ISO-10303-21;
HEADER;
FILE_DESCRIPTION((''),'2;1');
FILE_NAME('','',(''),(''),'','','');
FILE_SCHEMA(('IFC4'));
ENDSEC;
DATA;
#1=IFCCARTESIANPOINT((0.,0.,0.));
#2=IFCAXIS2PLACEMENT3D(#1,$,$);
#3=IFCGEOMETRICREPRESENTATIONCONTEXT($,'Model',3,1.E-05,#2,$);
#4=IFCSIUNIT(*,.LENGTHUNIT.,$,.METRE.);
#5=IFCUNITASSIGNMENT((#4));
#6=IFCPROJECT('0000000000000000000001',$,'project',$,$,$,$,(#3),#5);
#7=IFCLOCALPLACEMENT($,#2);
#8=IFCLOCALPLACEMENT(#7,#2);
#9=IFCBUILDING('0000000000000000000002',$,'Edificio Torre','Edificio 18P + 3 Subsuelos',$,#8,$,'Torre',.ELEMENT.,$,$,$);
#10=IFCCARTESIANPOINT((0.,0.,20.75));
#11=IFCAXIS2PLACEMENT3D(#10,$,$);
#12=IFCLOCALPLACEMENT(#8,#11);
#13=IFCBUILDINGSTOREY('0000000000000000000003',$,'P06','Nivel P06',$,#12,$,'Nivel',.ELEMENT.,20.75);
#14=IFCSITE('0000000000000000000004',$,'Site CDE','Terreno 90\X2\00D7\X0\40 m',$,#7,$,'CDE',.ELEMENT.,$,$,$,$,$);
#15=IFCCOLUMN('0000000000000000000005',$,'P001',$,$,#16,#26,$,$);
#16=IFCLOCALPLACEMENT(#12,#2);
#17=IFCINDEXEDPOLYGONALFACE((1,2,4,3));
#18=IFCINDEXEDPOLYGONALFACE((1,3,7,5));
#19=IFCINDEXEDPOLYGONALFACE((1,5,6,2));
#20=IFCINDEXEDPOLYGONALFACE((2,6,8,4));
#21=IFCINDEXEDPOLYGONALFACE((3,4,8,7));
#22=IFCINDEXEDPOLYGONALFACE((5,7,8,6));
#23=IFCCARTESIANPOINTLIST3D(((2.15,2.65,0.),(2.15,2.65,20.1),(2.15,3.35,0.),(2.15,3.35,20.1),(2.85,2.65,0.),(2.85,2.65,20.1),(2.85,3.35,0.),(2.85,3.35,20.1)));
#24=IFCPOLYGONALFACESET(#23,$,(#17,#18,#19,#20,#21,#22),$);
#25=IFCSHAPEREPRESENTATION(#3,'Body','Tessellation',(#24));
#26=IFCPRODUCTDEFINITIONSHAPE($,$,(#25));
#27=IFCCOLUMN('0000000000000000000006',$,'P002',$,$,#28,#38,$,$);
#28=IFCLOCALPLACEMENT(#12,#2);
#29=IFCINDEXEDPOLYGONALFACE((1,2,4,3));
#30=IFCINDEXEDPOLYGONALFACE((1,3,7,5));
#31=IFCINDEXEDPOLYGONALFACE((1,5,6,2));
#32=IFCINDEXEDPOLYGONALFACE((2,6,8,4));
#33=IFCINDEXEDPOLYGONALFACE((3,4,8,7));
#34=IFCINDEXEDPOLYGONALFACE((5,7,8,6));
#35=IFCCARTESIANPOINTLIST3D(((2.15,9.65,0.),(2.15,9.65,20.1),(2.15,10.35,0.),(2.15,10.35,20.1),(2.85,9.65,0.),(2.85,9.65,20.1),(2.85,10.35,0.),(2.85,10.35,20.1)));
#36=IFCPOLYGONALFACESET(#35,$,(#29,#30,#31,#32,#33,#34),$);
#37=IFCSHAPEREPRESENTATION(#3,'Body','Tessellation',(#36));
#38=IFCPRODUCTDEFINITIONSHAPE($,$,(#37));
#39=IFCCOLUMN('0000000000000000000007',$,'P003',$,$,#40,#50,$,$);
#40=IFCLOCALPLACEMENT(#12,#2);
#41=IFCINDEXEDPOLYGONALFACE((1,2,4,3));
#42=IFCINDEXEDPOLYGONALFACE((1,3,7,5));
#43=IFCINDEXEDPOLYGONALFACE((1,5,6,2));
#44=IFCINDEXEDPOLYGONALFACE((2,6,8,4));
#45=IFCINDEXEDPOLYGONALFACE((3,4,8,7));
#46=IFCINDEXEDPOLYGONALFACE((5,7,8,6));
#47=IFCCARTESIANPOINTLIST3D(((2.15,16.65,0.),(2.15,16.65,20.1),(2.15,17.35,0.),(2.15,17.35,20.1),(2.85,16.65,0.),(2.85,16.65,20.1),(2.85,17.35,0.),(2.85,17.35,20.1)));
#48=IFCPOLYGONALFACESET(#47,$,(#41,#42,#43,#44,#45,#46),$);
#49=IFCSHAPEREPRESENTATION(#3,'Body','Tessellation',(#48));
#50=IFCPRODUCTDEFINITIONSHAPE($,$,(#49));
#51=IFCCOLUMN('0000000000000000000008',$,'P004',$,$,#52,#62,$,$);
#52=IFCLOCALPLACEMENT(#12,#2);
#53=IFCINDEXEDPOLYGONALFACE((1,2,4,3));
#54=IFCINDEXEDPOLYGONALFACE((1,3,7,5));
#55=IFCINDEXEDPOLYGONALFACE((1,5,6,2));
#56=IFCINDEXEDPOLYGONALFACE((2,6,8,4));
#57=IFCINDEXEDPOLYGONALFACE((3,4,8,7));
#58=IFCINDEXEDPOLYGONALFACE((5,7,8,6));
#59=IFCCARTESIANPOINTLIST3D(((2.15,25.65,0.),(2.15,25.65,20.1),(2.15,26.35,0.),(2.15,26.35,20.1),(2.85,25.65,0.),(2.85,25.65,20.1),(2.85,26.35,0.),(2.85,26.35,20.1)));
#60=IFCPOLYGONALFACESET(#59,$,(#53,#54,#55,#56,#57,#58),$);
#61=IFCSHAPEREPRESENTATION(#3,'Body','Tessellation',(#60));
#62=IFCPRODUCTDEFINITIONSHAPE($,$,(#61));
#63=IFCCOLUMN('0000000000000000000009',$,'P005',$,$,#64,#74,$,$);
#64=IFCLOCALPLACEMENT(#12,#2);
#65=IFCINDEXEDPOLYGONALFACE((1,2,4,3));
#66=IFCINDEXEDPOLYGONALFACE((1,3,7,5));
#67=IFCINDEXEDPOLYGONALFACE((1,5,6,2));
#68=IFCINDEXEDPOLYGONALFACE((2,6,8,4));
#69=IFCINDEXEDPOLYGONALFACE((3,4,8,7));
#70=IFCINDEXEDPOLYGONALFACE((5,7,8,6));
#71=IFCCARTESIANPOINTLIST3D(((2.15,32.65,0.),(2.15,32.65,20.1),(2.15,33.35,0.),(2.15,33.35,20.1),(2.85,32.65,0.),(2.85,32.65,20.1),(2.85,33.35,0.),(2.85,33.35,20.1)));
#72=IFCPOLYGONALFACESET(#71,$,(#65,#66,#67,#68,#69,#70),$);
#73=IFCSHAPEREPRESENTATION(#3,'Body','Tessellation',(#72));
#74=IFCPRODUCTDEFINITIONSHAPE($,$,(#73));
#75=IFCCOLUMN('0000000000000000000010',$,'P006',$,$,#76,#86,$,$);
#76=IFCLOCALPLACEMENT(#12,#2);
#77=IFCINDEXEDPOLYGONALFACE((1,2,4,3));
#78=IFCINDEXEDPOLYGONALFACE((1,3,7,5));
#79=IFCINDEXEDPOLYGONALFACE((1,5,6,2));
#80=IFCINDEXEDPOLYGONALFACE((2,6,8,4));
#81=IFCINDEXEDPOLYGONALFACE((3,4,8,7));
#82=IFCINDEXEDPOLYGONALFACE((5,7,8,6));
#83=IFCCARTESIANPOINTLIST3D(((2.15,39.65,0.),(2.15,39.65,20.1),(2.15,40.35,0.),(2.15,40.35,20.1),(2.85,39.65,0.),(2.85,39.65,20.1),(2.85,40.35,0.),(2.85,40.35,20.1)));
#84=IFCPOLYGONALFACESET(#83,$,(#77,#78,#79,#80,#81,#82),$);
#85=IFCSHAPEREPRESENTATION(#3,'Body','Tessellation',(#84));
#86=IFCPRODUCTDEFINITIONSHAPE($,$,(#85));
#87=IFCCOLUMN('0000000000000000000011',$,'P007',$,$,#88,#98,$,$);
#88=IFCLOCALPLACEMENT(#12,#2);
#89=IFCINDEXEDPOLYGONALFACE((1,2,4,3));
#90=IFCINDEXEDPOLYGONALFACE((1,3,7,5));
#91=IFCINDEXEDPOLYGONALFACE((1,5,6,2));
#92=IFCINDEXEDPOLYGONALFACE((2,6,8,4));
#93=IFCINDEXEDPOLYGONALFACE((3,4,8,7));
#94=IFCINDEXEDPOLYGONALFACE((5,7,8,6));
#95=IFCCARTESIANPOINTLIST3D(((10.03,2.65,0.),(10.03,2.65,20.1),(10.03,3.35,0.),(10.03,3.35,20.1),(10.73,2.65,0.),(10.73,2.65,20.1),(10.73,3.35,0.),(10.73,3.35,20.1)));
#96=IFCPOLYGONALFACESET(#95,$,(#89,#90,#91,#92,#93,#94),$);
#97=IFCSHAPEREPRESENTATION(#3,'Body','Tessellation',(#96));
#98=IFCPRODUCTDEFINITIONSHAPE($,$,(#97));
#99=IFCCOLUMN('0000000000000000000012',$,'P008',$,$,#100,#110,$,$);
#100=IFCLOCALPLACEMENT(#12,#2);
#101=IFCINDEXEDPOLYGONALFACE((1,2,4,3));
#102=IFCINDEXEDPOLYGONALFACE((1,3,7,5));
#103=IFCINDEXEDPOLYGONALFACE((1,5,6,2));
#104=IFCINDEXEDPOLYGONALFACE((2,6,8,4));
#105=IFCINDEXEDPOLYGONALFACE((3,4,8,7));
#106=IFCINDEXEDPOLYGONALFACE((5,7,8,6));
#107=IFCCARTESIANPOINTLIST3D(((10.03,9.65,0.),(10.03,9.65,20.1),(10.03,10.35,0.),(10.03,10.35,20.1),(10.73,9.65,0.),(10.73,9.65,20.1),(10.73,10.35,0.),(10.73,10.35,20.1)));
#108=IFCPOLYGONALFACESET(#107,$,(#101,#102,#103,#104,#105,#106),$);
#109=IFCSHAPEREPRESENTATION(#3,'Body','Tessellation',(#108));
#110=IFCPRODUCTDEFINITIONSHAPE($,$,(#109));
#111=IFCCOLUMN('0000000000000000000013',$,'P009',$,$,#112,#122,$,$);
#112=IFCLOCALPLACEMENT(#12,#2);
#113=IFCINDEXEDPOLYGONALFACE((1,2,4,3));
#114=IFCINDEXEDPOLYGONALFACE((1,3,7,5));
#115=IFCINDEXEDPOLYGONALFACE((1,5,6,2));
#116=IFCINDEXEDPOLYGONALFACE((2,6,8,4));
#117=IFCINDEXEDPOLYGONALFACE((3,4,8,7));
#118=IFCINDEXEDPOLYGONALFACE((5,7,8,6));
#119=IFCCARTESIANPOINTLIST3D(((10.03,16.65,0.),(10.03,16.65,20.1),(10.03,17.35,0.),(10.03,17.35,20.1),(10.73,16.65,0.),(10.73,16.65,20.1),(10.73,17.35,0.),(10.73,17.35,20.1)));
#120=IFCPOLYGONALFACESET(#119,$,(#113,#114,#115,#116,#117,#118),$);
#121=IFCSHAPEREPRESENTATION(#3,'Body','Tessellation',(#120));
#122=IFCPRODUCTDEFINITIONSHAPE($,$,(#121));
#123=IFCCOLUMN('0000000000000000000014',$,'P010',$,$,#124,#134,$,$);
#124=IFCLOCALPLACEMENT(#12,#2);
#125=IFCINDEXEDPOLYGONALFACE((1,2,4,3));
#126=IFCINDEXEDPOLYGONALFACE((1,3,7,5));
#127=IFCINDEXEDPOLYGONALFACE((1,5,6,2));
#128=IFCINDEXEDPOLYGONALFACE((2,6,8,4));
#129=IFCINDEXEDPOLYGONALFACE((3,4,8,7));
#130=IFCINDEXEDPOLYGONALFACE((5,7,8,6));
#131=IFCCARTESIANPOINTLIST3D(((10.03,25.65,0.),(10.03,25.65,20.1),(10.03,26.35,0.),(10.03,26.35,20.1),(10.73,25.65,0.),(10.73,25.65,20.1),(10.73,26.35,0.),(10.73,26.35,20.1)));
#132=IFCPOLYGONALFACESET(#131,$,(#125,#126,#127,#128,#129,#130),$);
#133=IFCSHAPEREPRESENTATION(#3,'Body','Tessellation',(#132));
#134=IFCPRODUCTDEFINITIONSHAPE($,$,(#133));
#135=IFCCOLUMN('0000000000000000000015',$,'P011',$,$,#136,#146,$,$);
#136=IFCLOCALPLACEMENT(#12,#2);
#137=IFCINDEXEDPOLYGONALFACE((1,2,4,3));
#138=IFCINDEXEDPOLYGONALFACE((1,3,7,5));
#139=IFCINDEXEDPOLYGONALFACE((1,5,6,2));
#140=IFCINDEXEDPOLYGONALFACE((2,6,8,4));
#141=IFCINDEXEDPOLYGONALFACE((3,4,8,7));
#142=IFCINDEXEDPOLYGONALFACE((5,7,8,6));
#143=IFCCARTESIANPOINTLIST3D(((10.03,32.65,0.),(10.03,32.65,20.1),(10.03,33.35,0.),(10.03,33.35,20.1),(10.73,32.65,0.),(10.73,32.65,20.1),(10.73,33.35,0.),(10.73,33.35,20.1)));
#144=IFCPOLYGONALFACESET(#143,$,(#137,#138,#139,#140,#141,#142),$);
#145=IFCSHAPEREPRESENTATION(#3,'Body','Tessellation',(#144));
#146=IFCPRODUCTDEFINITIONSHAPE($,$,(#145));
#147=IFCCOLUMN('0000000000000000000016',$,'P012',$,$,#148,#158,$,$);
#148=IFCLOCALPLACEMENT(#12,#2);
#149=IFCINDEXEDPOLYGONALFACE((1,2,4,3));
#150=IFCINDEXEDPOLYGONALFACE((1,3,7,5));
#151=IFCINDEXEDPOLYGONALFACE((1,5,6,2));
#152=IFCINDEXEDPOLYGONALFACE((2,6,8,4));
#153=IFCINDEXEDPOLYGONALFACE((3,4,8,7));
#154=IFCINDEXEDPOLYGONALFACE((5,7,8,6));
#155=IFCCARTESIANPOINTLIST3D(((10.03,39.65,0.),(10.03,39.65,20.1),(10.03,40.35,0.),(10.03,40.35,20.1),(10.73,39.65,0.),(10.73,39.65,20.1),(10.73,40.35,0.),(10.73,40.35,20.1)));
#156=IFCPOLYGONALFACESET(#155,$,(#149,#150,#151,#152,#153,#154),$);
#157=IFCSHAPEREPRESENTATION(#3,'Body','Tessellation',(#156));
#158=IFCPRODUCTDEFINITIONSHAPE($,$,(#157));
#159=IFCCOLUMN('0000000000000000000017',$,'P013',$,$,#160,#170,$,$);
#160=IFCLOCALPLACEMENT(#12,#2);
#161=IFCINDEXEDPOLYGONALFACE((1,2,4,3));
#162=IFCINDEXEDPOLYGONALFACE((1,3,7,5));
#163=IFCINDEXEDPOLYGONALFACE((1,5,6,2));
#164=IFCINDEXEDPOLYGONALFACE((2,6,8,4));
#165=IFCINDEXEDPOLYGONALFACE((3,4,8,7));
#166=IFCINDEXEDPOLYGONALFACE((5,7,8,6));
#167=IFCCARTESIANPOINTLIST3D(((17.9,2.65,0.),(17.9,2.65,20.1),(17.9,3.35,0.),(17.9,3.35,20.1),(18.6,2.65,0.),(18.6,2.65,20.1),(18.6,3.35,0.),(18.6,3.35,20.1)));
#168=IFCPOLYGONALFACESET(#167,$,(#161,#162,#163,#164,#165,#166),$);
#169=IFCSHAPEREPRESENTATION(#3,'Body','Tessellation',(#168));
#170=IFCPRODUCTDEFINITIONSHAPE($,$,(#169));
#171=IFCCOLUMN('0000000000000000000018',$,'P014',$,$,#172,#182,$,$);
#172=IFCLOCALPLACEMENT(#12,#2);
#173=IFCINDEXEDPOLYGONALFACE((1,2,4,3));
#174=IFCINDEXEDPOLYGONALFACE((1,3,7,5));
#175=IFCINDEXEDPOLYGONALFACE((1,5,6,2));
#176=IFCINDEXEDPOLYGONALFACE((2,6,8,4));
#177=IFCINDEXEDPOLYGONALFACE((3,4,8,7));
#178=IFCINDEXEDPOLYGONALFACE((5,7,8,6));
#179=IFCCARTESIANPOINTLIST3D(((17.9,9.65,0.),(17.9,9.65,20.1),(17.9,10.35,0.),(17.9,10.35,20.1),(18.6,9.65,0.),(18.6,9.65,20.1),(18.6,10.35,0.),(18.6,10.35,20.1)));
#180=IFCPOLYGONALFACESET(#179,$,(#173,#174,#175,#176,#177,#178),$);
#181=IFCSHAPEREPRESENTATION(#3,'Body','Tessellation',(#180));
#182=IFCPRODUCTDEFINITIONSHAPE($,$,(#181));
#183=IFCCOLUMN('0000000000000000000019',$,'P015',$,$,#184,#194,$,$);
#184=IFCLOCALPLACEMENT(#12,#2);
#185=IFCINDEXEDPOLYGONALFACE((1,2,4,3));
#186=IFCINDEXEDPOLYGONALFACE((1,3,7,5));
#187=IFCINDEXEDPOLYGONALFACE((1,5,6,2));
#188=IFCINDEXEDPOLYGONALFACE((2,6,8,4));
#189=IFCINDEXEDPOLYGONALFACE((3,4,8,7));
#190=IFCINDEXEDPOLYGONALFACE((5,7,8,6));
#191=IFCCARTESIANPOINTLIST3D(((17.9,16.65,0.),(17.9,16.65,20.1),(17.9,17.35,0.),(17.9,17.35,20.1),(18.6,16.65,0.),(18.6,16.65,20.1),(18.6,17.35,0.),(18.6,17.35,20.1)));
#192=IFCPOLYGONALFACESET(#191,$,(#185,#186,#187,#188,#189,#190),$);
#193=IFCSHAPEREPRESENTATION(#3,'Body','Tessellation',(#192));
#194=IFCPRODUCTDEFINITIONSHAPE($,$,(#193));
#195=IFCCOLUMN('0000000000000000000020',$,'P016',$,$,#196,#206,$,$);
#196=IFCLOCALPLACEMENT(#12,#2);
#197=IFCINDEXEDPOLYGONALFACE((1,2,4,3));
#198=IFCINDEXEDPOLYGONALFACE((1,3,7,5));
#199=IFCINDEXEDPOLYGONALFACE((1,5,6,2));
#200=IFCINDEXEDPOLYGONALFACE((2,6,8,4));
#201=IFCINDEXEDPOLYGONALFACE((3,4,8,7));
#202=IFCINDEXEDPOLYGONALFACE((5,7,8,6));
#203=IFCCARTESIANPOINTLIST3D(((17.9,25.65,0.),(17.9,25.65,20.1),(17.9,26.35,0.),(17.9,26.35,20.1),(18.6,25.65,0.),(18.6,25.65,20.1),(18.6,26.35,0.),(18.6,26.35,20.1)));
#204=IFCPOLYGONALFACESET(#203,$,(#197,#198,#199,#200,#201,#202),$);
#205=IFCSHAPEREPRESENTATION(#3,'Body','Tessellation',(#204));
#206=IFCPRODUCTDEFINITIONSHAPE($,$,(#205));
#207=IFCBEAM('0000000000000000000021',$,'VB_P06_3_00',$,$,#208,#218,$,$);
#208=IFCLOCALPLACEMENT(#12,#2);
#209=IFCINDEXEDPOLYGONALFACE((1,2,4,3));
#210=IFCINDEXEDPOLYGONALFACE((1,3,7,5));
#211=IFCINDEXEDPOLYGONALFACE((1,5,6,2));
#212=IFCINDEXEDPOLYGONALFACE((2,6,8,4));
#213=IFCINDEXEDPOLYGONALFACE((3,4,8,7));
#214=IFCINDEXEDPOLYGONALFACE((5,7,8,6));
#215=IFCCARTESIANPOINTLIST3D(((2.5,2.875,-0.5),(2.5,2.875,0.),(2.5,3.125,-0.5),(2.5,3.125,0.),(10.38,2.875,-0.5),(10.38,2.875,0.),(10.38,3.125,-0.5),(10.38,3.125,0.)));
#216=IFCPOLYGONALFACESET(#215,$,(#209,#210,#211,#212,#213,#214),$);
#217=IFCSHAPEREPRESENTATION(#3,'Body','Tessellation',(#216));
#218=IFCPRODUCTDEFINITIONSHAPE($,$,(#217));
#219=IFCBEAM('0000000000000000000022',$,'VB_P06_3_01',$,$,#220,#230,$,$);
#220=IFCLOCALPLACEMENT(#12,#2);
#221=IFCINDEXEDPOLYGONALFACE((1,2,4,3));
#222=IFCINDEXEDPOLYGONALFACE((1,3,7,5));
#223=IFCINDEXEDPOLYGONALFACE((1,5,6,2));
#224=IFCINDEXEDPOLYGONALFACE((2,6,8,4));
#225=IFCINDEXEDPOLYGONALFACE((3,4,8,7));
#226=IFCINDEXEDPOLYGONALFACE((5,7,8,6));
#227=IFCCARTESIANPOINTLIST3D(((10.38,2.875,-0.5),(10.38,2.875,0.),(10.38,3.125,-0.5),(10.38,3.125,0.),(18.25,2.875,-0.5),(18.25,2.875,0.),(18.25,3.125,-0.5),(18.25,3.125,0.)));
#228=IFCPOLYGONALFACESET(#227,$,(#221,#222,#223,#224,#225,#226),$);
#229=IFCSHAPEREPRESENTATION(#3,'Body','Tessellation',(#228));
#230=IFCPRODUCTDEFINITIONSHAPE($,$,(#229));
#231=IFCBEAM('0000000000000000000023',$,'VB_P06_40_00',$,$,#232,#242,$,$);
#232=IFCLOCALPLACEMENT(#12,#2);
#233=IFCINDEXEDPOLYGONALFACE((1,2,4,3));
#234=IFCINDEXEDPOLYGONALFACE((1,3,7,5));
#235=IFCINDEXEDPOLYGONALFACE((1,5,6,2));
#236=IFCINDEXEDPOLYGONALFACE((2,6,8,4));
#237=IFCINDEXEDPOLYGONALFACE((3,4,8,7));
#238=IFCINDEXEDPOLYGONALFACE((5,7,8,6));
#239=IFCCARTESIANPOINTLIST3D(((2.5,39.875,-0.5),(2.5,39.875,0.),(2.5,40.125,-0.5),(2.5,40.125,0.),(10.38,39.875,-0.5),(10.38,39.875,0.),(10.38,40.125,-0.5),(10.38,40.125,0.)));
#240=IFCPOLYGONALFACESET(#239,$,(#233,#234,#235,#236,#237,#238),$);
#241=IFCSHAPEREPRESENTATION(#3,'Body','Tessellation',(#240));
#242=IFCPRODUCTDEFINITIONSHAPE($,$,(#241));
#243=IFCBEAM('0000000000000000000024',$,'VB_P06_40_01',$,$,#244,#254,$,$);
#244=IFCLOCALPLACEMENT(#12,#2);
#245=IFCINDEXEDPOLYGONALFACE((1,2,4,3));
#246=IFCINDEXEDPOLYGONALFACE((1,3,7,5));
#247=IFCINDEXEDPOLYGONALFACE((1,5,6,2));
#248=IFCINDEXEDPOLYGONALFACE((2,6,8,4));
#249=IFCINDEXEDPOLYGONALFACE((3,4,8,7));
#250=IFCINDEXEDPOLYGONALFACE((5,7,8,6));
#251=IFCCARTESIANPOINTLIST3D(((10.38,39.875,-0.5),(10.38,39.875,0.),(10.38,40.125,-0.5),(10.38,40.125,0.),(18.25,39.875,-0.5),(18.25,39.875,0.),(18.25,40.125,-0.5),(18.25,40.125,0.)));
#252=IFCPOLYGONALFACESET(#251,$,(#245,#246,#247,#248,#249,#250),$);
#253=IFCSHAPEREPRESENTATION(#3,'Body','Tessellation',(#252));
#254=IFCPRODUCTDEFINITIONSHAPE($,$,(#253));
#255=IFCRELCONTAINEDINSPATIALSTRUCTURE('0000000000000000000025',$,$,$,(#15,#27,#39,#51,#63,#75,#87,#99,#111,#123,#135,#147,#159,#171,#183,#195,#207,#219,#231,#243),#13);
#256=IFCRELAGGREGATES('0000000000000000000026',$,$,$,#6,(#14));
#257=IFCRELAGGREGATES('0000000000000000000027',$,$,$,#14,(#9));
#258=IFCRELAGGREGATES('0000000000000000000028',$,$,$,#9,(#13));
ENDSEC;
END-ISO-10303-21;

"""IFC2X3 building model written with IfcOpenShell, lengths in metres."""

from ifc_helpers import new_model, si_unit, frame, origin, origin_2d, place, context, project, spatial, rectangle, extrude, element, save


model = new_model("IFC2X3")

# Units and contexts
model_context = context("Model", 3, precision=1e-05, world=origin())
ifc_project = project(units=[si_unit("LENGTHUNIT", "METRE")], contexts=[model_context])

# Site, building, storey
site_placement = place(None, origin())
site = spatial("IfcSite", under=ifc_project, at=site_placement, Name="Site CDE", Description="Terreno 90×40 m", LongName="CDE", CompositionType="ELEMENT")
building_placement = place(site_placement, origin())
building = spatial("IfcBuilding", under=site, at=building_placement, Name="Edificio Torre", Description="Edificio 18P + 3 Subsuelos", LongName="Torre", CompositionType="ELEMENT")
storey_placement = place(building_placement, frame((0.0, 0.0, 20.75)))
storey = spatial("IfcBuildingStorey", under=building, at=storey_placement, Name="P06", Description="Nivel P06", LongName="Nivel", CompositionType="ELEMENT", Elevation=20.75)

# Columns
for number, where, name in (
    (1, (2.5, 3.0, 0.0), "P001"),
    (2, (2.5, 10.0, 0.0), "P002"),
    (3, (2.5, 17.0, 0.0), "P003"),
    (4, (2.5, 26.0, 0.0), "P004"),
    (5, (2.5, 33.0, 0.0), "P005"),
    (6, (2.5, 40.0, 0.0), "P006"),
    (7, (10.38, 3.0, 0.0), "P007"),
    (8, (10.38, 10.0, 0.0), "P008"),
    (9, (10.38, 17.0, 0.0), "P009"),
    (10, (10.38, 26.0, 0.0), "P010"),
    (11, (10.38, 33.0, 0.0), "P011"),
    (12, (10.38, 40.0, 0.0), "P012"),
    (13, (18.25, 3.0, 0.0), "P013"),
    (14, (18.25, 10.0, 0.0), "P014"),
    (15, (18.25, 17.0, 0.0), "P015"),
    (16, (18.25, 26.0, 0.0), "P016"),
):
    element("IfcColumn", number, at=place(storey_placement, frame(where)), inside=storey, Name=name, context=model_context, shape_type="SweptSolid", body=[
        extrude(rectangle(XDim=0.7, YDim=0.7, at=origin_2d()), origin(), (0.0, 0.0, 1.0), 20.1),
    ])

# Beams
beam_1_placement = place(storey_placement, frame((6.44, 3.0, -0.5)))
element("IfcBeam", 17, at=beam_1_placement, inside=storey, Name="VB_P06_3_00", context=model_context, shape_type="SweptSolid", body=[
    extrude(rectangle(XDim=7.88, YDim=0.25, at=origin_2d()), origin(), (0.0, 0.0, 1.0), 0.5),
])
beam_2_placement = place(storey_placement, frame((14.315, 3.0, -0.5)))
element("IfcBeam", 18, at=beam_2_placement, inside=storey, Name="VB_P06_3_01", context=model_context, shape_type="SweptSolid", body=[
    extrude(rectangle(XDim=7.87, YDim=0.25, at=origin_2d()), origin(), (0.0, 0.0, 1.0), 0.5),
])
beam_3_placement = place(storey_placement, frame((6.44, 40.0, -0.5)))
element("IfcBeam", 19, at=beam_3_placement, inside=storey, Name="VB_P06_40_00", context=model_context, shape_type="SweptSolid", body=[
    extrude(rectangle(XDim=7.88, YDim=0.25, at=origin_2d()), origin(), (0.0, 0.0, 1.0), 0.5),
])
beam_4_placement = place(storey_placement, frame((14.315, 40.0, -0.5)))
element("IfcBeam", 20, at=beam_4_placement, inside=storey, Name="VB_P06_40_01", context=model_context, shape_type="SweptSolid", body=[
    extrude(rectangle(XDim=7.87, YDim=0.25, at=origin_2d()), origin(), (0.0, 0.0, 1.0), 0.5),
])

save(model, "model.ifc")
